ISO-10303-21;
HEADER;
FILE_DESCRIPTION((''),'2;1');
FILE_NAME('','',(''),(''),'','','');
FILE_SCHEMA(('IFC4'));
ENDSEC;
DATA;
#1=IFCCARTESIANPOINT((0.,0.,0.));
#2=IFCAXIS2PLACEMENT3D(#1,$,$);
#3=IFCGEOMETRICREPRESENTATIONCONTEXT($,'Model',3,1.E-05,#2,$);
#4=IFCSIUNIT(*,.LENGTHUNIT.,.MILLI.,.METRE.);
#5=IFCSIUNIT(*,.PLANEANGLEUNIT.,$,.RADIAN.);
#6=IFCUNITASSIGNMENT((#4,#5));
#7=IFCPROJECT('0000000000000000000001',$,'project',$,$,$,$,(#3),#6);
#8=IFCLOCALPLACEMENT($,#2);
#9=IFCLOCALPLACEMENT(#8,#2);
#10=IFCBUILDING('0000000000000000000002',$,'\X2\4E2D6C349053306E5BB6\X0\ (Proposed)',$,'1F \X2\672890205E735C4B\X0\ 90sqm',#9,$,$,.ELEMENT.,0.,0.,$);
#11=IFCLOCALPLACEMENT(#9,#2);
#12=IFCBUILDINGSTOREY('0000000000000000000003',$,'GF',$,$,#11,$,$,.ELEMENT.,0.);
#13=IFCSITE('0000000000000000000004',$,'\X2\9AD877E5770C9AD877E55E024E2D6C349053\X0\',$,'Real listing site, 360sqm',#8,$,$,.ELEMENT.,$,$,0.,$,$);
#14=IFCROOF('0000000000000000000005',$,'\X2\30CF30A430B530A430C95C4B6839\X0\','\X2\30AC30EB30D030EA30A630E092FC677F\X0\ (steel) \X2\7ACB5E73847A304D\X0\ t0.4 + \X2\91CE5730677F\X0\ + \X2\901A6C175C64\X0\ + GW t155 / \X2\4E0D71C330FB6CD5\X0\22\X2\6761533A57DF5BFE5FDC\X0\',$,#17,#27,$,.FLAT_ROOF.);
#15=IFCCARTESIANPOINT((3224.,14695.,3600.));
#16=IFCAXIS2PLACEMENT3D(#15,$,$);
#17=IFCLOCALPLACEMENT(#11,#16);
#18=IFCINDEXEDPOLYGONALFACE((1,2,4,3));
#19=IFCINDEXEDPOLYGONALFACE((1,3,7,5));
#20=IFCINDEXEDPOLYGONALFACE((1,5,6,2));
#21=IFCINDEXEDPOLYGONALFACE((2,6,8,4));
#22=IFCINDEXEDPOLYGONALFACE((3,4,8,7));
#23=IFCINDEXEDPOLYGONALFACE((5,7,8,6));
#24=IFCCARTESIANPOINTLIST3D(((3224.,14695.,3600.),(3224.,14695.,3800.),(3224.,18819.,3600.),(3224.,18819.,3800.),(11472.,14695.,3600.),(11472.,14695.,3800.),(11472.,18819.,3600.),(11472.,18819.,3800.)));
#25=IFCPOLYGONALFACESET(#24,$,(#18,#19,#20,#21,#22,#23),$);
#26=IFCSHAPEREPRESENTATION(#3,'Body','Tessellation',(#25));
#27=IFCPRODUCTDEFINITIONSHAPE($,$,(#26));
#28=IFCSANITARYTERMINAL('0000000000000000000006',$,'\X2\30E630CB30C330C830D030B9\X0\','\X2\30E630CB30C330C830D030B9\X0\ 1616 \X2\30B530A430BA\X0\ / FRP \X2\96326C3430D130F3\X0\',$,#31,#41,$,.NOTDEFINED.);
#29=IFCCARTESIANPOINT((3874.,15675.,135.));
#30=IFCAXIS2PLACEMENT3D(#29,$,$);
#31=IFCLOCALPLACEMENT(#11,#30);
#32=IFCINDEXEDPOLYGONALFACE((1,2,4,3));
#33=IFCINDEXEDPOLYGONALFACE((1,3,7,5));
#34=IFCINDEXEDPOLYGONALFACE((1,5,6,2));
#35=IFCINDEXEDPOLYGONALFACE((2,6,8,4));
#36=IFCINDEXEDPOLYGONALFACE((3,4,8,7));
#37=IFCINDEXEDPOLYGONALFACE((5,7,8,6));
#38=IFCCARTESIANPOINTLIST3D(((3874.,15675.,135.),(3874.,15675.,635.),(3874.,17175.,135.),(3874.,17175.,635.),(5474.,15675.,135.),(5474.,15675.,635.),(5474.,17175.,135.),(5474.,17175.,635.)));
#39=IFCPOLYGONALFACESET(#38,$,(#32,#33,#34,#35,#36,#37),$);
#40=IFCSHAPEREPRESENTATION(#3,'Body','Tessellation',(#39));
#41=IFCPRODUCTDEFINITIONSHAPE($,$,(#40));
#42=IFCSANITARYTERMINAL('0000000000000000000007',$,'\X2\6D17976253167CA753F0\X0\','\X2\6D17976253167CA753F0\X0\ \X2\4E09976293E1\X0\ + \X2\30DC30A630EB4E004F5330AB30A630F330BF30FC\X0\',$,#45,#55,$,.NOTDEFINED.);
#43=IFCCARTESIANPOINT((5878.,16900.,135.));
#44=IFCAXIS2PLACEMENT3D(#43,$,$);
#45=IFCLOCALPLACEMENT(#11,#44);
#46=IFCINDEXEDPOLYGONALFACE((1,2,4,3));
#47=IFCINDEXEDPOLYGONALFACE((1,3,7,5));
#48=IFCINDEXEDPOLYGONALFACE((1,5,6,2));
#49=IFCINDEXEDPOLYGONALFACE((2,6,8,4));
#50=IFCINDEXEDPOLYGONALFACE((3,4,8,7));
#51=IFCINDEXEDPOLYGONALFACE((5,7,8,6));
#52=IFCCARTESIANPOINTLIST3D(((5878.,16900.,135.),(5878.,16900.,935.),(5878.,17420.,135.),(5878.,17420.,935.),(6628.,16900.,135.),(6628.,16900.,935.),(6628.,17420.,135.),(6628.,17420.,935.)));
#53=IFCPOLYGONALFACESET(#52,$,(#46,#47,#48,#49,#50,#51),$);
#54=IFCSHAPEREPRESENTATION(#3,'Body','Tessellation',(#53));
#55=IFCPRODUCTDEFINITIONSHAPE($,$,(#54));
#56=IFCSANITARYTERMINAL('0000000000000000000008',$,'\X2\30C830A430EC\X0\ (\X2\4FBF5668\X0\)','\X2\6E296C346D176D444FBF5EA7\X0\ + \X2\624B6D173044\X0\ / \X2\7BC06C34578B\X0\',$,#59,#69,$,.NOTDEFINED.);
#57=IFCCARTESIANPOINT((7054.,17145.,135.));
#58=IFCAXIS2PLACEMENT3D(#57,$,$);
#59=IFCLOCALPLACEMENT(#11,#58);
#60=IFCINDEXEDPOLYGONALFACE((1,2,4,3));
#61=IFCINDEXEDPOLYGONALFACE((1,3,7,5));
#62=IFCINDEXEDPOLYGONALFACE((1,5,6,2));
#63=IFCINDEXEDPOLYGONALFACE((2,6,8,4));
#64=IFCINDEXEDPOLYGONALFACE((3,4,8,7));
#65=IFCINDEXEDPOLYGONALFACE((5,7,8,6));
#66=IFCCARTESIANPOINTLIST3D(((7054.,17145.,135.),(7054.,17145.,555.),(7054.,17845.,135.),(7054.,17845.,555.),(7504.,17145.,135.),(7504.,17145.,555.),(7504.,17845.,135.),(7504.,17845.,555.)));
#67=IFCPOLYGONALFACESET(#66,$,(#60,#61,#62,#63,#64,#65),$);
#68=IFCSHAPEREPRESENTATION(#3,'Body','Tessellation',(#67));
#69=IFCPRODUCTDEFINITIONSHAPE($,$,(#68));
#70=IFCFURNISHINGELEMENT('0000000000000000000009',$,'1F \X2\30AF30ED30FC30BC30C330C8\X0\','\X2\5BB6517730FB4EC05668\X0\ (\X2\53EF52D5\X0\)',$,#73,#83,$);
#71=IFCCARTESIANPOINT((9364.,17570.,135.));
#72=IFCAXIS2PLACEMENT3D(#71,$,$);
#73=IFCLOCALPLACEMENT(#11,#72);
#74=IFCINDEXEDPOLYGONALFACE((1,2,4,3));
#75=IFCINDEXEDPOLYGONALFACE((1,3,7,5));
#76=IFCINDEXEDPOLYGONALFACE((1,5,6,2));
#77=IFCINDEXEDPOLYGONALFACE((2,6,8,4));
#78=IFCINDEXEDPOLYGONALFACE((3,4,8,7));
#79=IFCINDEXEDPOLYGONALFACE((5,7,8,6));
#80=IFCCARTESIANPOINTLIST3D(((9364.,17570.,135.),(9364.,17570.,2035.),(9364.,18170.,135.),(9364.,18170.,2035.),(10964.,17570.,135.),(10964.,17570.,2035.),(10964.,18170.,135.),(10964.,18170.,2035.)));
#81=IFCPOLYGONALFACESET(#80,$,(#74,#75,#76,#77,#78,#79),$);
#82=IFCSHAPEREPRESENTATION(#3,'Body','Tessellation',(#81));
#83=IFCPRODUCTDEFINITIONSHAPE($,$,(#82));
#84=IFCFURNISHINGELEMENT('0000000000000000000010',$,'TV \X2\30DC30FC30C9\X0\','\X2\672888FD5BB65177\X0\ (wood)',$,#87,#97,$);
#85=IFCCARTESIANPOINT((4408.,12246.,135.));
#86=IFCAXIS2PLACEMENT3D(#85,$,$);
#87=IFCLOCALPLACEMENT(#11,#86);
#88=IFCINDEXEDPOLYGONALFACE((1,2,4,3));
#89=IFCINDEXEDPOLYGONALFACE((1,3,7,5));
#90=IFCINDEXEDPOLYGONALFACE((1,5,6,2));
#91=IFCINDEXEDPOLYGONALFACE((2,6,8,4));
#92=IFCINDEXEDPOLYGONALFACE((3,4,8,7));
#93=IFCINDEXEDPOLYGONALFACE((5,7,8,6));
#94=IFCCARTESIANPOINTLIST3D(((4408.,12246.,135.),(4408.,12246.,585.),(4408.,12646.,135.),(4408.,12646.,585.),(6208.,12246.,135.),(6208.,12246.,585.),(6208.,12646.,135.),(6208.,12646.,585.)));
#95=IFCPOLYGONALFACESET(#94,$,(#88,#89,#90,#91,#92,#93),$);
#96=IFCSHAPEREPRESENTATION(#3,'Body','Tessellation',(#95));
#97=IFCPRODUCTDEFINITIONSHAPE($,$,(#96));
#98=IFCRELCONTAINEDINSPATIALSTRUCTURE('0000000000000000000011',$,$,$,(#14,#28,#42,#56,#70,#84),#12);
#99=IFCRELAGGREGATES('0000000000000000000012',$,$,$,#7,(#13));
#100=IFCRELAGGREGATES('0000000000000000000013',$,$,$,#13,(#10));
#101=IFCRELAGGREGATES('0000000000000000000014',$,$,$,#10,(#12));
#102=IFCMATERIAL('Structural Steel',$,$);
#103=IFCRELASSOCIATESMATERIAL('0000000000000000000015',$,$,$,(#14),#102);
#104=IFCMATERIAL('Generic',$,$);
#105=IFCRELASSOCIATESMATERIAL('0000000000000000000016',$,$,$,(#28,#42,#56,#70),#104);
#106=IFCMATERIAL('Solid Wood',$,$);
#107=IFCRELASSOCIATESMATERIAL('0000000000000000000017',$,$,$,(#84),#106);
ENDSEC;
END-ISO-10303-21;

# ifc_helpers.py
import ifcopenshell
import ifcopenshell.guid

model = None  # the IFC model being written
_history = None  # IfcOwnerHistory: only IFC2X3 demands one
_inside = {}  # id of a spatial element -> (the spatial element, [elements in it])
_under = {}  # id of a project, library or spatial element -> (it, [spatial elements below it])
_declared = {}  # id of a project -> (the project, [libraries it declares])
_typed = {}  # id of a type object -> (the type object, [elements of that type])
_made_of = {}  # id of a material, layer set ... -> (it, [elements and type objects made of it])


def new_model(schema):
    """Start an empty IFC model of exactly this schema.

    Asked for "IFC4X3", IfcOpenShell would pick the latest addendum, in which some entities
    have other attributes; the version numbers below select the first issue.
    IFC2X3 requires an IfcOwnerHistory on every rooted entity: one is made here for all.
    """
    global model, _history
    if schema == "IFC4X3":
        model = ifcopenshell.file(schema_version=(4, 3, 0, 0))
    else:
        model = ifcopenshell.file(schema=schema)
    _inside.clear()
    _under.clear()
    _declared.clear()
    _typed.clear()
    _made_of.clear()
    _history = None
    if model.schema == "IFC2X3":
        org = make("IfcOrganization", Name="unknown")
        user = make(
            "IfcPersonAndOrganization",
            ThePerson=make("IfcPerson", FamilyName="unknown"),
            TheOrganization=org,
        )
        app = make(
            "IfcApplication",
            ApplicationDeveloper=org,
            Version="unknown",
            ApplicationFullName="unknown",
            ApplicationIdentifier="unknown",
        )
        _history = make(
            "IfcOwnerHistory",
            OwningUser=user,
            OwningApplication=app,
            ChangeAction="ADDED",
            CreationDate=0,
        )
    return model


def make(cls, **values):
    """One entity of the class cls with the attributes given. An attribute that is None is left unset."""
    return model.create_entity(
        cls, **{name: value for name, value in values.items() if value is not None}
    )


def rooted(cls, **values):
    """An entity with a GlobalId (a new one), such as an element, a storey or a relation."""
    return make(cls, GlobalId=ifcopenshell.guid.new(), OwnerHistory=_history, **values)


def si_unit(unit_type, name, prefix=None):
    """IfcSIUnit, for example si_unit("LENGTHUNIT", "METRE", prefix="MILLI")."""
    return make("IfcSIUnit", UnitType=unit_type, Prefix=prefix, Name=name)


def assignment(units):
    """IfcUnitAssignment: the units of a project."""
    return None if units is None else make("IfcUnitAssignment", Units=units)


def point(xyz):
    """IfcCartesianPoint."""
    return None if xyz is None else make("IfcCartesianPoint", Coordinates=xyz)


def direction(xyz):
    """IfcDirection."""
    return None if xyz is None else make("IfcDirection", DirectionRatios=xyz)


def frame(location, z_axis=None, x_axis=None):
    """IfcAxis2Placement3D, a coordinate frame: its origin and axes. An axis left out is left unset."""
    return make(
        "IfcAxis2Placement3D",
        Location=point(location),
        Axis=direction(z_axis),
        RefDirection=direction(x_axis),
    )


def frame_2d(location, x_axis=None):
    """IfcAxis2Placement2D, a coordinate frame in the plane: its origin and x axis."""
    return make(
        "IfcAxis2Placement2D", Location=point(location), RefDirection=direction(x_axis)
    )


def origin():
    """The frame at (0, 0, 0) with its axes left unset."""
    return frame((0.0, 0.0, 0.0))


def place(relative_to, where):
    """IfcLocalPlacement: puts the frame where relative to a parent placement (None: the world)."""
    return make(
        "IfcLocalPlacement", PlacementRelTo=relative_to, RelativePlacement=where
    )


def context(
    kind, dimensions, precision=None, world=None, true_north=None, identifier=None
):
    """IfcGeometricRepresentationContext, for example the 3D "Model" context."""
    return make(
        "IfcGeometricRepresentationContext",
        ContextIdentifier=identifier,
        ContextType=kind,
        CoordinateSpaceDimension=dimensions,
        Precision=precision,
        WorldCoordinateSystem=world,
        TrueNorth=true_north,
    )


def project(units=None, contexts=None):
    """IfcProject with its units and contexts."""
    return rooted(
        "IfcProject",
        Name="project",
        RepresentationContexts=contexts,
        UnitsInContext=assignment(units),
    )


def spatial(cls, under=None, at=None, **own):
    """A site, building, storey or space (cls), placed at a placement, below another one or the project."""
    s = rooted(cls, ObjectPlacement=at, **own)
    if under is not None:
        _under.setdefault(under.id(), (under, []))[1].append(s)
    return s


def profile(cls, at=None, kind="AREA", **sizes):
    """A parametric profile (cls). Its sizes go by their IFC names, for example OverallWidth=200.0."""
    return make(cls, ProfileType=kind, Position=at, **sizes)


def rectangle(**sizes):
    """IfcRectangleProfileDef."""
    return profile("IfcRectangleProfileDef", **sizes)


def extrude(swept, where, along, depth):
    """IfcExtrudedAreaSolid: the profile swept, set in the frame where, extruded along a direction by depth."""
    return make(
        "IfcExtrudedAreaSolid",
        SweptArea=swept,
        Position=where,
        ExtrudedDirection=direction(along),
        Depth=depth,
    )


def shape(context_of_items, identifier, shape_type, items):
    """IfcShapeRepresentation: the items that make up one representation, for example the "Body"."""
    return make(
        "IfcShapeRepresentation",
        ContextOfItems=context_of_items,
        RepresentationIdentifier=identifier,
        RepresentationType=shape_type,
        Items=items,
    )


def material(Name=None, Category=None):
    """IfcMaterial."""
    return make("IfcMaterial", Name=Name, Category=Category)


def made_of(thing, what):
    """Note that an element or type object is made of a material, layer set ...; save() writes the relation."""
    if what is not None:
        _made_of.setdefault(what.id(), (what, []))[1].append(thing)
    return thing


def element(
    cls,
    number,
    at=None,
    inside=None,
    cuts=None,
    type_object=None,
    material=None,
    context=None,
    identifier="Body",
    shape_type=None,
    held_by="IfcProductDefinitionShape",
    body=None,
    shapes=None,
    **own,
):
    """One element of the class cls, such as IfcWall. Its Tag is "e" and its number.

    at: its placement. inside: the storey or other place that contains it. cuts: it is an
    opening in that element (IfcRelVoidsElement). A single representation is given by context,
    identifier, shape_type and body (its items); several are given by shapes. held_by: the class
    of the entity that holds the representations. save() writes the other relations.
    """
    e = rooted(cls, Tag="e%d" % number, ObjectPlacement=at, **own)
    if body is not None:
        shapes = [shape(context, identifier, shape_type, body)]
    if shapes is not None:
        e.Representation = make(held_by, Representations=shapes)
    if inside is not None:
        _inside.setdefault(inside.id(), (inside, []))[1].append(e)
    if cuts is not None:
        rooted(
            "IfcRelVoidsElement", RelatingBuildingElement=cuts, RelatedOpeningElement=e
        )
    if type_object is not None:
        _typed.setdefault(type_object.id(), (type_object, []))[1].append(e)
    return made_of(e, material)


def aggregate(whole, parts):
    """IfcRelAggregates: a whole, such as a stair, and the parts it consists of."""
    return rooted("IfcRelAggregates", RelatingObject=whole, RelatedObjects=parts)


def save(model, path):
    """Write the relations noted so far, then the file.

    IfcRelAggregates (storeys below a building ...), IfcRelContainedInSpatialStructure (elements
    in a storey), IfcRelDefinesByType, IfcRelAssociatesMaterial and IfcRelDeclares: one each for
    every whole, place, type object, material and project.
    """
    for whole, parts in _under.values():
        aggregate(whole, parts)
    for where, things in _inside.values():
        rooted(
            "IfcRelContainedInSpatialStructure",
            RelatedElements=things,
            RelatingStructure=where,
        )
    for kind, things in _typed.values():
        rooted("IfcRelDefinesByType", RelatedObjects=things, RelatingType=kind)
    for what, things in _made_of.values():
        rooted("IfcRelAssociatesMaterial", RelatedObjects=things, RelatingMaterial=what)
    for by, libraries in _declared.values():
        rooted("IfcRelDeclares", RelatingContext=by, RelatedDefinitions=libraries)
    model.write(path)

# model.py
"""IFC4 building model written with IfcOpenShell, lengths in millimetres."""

from ifc_helpers import new_model, si_unit, frame, frame_2d, origin, place, context, project, spatial, rectangle, extrude, material, element, save


model = new_model("IFC4")

# Units and contexts
model_context = context("Model", 3, precision=1e-05, world=origin())
ifc_project = project(units=[si_unit("LENGTHUNIT", "METRE", prefix="MILLI"), si_unit("PLANEANGLEUNIT", "RADIAN")], contexts=[model_context])

# Site, building, storey
site_placement = place(None, origin())
site = spatial("IfcSite", under=ifc_project, at=site_placement, Name="高知県高知市中水道", ObjectType="Real listing site, 360sqm", CompositionType="ELEMENT", RefElevation=0.0)
building_placement = place(site_placement, origin())
building = spatial("IfcBuilding", under=site, at=building_placement, Name="中水道の家 (Proposed)", ObjectType="1F 木造平屋 90sqm", CompositionType="ELEMENT", ElevationOfRefHeight=0.0, ElevationOfTerrain=0.0)
storey_placement = place(building_placement, origin())
storey = spatial("IfcBuildingStorey", under=building, at=storey_placement, Name="GF", CompositionType="ELEMENT", Elevation=0.0)

# Shared definitions
ifc_material_1 = material(Name="Solid Wood")

# Roof
ifc_material_2 = material(Name="Structural Steel")
roof_placement = place(storey_placement, frame((3224.0, 14695.0, 3600.0)))
element("IfcRoof", 1, at=roof_placement, inside=storey, material=ifc_material_2, Name="ハイサイド屋根", Description="ガルバリウム鋼板 (steel) 立平葺き t0.4 + 野地板 + 通気層 + GW t155 / 不燃・法22条区域対応", PredefinedType="FLAT_ROOF", context=model_context, shape_type="SweptSolid", body=[
    extrude(rectangle(XDim=8248.0, YDim=4124.0, at=frame_2d((4124.0, 2062.0))), frame((3224.0, 14695.0, 3600.0)), (0.0, 0.0, 1.0), 200.0),
])

# Sanitary terminals
ifc_material_3 = material(Name="Generic")
sanitary_terminal_1_placement = place(storey_placement, frame((3874.0, 15675.0, 135.0)))
element("IfcSanitaryTerminal", 2, at=sanitary_terminal_1_placement, inside=storey, material=ifc_material_3, Name="ユニットバス", Description="ユニットバス 1616 サイズ / FRP 防水パン", PredefinedType="NOTDEFINED", context=model_context, shape_type="SweptSolid", body=[
    extrude(rectangle(XDim=1600.0, YDim=1500.0, at=frame_2d((800.0, 750.0))), frame((3874.0, 15675.0, 135.0)), (0.0, 0.0, 1.0), 500.0),
])
sanitary_terminal_2_placement = place(storey_placement, frame((5878.0, 16900.0, 135.0)))
element("IfcSanitaryTerminal", 3, at=sanitary_terminal_2_placement, inside=storey, material=ifc_material_3, Name="洗面化粧台", Description="洗面化粧台 三面鏡 + ボウル一体カウンター", PredefinedType="NOTDEFINED", context=model_context, shape_type="SweptSolid", body=[
    extrude(rectangle(XDim=750.0, YDim=520.0, at=frame_2d((375.0, 260.0))), frame((5878.0, 16900.0, 135.0)), (0.0, 0.0, 1.0), 800.0),
])
sanitary_terminal_3_placement = place(storey_placement, frame((7054.0, 17145.0, 135.0)))
element("IfcSanitaryTerminal", 4, at=sanitary_terminal_3_placement, inside=storey, material=ifc_material_3, Name="トイレ (便器)", Description="温水洗浄便座 + 手洗い / 節水型", PredefinedType="NOTDEFINED", context=model_context, shape_type="SweptSolid", body=[
    extrude(rectangle(XDim=450.0, YDim=700.0, at=frame_2d((225.0, 350.0))), frame((7054.0, 17145.0, 135.0)), (0.0, 0.0, 1.0), 420.0),
])

# Furnishing elements
furnishing_1_placement = place(storey_placement, frame((9364.0, 17570.0, 135.0)))
element("IfcFurnishingElement", 5, at=furnishing_1_placement, inside=storey, material=ifc_material_3, Name="1F クローゼット", Description="家具・什器 (可動)", context=model_context, shape_type="SweptSolid", body=[
    extrude(rectangle(XDim=1600.0, YDim=600.0, at=frame_2d((800.0, 300.0))), frame((9364.0, 17570.0, 135.0)), (0.0, 0.0, 1.0), 1900.0),
])
furnishing_2_placement = place(storey_placement, frame((4408.0, 12246.0, 135.0)))
element("IfcFurnishingElement", 6, at=furnishing_2_placement, inside=storey, material=ifc_material_1, Name="TV ボード", Description="木製家具 (wood)", context=model_context, shape_type="SweptSolid", body=[
    extrude(rectangle(XDim=1800.0, YDim=400.0, at=frame_2d((900.0, 200.0))), frame((4408.0, 12246.0, 135.0)), (0.0, 0.0, 1.0), 450.0),
])

save(model, "model.ifc")
